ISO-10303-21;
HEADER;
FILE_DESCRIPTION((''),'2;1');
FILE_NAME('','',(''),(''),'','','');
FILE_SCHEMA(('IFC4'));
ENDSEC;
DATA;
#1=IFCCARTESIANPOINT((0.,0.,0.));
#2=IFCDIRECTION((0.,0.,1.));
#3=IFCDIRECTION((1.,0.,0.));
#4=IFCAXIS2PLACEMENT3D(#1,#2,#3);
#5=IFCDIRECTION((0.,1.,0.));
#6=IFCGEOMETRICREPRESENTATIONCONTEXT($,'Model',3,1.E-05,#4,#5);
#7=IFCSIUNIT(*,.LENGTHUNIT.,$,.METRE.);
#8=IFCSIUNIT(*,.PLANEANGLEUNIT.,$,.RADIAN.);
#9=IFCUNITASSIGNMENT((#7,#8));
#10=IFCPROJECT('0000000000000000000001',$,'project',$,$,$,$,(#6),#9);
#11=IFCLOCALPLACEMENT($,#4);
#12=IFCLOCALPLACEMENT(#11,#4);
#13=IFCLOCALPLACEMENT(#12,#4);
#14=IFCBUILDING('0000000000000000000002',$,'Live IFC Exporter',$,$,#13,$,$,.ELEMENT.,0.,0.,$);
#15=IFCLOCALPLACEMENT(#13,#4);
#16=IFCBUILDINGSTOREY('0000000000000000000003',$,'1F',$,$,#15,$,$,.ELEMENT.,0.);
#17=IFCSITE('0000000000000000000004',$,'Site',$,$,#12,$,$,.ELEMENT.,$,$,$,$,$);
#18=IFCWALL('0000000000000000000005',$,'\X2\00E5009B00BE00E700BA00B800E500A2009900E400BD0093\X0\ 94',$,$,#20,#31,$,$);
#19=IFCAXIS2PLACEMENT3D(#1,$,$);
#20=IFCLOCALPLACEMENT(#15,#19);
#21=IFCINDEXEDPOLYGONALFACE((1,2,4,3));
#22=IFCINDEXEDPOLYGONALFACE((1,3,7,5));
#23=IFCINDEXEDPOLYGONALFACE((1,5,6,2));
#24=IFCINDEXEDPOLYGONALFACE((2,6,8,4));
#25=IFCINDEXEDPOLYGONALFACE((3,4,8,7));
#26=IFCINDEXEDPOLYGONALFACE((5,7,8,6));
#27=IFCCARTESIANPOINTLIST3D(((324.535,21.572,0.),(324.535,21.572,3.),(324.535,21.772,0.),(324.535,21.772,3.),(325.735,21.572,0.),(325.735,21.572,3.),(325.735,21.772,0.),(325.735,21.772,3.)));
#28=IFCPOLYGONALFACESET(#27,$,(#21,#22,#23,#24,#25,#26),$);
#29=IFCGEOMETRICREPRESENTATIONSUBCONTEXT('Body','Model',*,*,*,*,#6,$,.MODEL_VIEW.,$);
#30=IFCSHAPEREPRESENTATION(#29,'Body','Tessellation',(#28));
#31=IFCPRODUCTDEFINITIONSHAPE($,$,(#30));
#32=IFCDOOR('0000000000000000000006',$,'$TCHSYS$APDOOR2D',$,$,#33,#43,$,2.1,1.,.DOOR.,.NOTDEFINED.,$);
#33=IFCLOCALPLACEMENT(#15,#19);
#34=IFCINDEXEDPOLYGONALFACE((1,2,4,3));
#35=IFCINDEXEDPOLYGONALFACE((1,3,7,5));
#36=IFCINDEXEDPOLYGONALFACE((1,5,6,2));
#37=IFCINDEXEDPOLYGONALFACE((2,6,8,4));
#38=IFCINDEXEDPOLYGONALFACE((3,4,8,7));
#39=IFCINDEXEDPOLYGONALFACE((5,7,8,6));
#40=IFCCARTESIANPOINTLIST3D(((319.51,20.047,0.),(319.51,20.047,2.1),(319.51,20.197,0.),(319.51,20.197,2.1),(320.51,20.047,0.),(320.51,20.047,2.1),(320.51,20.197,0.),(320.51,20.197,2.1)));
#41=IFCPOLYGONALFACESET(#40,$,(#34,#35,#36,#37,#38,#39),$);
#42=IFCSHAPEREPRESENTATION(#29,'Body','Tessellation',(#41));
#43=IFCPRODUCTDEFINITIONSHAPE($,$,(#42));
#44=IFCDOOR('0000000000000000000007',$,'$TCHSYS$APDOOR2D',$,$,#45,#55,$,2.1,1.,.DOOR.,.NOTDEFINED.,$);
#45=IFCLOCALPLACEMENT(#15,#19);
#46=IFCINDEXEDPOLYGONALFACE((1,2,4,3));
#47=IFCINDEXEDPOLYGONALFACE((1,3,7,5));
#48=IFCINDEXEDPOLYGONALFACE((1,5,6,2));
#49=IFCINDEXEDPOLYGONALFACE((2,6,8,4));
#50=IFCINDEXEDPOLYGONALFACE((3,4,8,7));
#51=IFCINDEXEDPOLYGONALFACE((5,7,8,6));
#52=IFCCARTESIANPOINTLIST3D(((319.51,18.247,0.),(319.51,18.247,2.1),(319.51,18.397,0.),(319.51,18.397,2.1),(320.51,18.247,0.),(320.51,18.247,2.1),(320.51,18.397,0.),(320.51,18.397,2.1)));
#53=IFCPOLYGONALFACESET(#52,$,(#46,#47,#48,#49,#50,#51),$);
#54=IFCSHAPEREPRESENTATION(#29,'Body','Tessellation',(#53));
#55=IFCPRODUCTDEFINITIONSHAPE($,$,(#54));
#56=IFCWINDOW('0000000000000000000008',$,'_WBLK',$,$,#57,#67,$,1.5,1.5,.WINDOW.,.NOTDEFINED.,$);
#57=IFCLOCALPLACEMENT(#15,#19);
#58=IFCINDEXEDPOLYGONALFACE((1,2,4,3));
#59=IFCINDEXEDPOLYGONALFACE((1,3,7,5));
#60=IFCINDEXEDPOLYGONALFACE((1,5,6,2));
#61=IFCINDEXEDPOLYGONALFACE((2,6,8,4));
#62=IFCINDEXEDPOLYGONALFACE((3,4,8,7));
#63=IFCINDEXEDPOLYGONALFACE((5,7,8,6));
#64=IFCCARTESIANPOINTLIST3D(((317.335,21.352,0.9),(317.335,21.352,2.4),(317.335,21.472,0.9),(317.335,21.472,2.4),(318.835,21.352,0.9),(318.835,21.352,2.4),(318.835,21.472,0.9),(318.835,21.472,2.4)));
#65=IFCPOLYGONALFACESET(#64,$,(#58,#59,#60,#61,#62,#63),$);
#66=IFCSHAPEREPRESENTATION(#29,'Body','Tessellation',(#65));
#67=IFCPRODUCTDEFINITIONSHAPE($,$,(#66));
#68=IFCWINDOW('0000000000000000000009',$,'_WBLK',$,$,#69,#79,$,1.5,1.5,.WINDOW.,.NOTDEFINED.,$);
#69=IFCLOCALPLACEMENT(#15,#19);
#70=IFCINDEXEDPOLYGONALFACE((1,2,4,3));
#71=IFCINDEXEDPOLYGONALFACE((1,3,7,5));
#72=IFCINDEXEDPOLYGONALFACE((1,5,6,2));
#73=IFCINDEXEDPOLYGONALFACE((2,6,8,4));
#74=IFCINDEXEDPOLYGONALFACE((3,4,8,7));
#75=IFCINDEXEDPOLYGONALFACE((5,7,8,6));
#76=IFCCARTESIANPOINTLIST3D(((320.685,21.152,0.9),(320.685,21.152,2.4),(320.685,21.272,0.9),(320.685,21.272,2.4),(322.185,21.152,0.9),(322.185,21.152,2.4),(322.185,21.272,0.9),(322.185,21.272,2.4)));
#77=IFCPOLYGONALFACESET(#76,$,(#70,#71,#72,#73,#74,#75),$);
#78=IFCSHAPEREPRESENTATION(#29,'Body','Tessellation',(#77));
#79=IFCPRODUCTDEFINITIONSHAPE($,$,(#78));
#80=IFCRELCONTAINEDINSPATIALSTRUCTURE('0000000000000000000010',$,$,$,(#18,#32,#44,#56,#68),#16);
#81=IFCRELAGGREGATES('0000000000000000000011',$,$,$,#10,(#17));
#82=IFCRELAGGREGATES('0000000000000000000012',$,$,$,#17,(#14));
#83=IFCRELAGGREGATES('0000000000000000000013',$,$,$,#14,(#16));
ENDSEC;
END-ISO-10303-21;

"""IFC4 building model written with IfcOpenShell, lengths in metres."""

from ifc_helpers import new_model, si_unit, direction, frame, frame_2d, origin_with_axes, place, context, subcontext, project, spatial, rectangle, extrude, element, save


model = new_model("IFC4")

# Units and contexts
model_context = context("Model", 3, precision=1e-05, world=origin_with_axes(), true_north=direction((0.0, 1.0, 0.0)))
body_context = subcontext(model_context, "Body", "Model", "MODEL_VIEW")
ifc_project = project(units=[si_unit("LENGTHUNIT", "METRE"), si_unit("PLANEANGLEUNIT", "RADIAN")], contexts=[model_context])

# Site, building, storey
placement = place(None, origin_with_axes())
site_placement = place(placement, origin_with_axes())
site = spatial("IfcSite", under=ifc_project, at=site_placement, Name="Site", CompositionType="ELEMENT")
building_placement = place(site_placement, origin_with_axes())
building = spatial("IfcBuilding", under=site, at=building_placement, Name="Live IFC Exporter", CompositionType="ELEMENT", ElevationOfRefHeight=0.0, ElevationOfTerrain=0.0)
storey_placement = place(building_placement, origin_with_axes())
storey = spatial("IfcBuildingStorey", under=building, at=storey_placement, Name="1F", CompositionType="ELEMENT", Elevation=0.0)

# Wall
wall_1_placement = place(storey_placement, frame((325.135, 21.672, 0.0), z_axis=(0.0, 0.0, 1.0), x_axis=(1.0, 0.0, 0.0)))
element("IfcWall", 1, at=wall_1_placement, inside=storey, Name="å\u009b¾çº¸å¢\u0099ä½\u0093 94", context=body_context, shape_type="SweptSolid", body=[
    extrude(rectangle(XDim=1.2, YDim=0.2, at=frame_2d((0.0, 0.0), x_axis=(1.0, 0.0, 0.0))), frame((0.0, 0.0, 0.0), z_axis=(0.0, 0.0, 1.0)), (0.0, 0.0, 1.0), 3.0),
])

# Doors
for number, where, z_axis, x_axis, name in (
    (2, (320.01, 20.122, 0.0), (0.0, 0.0, 1.0), (1.0, 0.0, 0.0), "$TCHSYS$APDOOR2D"),
    (3, (320.01, 18.322, 0.0), (0.0, 0.0, 1.0), (1.0, 0.0, 0.0), "$TCHSYS$APDOOR2D"),
):
    element("IfcDoor", number, at=place(storey_placement, frame(where, z_axis=z_axis, x_axis=x_axis)), inside=storey, Name=name, OperationType="NOTDEFINED", OverallHeight=2.1, OverallWidth=1.0, PredefinedType="DOOR", context=body_context, shape_type="SweptSolid", body=[
        extrude(rectangle(XDim=1.0, YDim=0.15, at=frame_2d((0.0, 0.0), x_axis=(1.0, 0.0, 0.0))), frame((0.0, 0.0, 0.0), z_axis=(0.0, 0.0, 1.0)), (0.0, 0.0, 1.0), 2.1),
    ])

# Windows
for number, where, z_axis, x_axis, name in (
    (4, (318.085, 21.412, 0.9), (0.0, 0.0, 1.0), (1.0, 0.0, 0.0), "_WBLK"),
    (5, (321.435, 21.212, 0.9), (0.0, 0.0, 1.0), (1.0, 0.0, 0.0), "_WBLK"),
):
    element("IfcWindow", number, at=place(storey_placement, frame(where, z_axis=z_axis, x_axis=x_axis)), inside=storey, Name=name, OverallHeight=1.5, OverallWidth=1.5, PartitioningType="NOTDEFINED", PredefinedType="WINDOW", context=body_context, shape_type="SweptSolid", body=[
        extrude(rectangle(XDim=1.5, YDim=0.12, at=frame_2d((0.0, 0.0), x_axis=(1.0, 0.0, 0.0))), frame((0.0, 0.0, 0.0), z_axis=(0.0, 0.0, 1.0)), (0.0, 0.0, 1.0), 1.5),
    ])

save(model, "model.ifc")
